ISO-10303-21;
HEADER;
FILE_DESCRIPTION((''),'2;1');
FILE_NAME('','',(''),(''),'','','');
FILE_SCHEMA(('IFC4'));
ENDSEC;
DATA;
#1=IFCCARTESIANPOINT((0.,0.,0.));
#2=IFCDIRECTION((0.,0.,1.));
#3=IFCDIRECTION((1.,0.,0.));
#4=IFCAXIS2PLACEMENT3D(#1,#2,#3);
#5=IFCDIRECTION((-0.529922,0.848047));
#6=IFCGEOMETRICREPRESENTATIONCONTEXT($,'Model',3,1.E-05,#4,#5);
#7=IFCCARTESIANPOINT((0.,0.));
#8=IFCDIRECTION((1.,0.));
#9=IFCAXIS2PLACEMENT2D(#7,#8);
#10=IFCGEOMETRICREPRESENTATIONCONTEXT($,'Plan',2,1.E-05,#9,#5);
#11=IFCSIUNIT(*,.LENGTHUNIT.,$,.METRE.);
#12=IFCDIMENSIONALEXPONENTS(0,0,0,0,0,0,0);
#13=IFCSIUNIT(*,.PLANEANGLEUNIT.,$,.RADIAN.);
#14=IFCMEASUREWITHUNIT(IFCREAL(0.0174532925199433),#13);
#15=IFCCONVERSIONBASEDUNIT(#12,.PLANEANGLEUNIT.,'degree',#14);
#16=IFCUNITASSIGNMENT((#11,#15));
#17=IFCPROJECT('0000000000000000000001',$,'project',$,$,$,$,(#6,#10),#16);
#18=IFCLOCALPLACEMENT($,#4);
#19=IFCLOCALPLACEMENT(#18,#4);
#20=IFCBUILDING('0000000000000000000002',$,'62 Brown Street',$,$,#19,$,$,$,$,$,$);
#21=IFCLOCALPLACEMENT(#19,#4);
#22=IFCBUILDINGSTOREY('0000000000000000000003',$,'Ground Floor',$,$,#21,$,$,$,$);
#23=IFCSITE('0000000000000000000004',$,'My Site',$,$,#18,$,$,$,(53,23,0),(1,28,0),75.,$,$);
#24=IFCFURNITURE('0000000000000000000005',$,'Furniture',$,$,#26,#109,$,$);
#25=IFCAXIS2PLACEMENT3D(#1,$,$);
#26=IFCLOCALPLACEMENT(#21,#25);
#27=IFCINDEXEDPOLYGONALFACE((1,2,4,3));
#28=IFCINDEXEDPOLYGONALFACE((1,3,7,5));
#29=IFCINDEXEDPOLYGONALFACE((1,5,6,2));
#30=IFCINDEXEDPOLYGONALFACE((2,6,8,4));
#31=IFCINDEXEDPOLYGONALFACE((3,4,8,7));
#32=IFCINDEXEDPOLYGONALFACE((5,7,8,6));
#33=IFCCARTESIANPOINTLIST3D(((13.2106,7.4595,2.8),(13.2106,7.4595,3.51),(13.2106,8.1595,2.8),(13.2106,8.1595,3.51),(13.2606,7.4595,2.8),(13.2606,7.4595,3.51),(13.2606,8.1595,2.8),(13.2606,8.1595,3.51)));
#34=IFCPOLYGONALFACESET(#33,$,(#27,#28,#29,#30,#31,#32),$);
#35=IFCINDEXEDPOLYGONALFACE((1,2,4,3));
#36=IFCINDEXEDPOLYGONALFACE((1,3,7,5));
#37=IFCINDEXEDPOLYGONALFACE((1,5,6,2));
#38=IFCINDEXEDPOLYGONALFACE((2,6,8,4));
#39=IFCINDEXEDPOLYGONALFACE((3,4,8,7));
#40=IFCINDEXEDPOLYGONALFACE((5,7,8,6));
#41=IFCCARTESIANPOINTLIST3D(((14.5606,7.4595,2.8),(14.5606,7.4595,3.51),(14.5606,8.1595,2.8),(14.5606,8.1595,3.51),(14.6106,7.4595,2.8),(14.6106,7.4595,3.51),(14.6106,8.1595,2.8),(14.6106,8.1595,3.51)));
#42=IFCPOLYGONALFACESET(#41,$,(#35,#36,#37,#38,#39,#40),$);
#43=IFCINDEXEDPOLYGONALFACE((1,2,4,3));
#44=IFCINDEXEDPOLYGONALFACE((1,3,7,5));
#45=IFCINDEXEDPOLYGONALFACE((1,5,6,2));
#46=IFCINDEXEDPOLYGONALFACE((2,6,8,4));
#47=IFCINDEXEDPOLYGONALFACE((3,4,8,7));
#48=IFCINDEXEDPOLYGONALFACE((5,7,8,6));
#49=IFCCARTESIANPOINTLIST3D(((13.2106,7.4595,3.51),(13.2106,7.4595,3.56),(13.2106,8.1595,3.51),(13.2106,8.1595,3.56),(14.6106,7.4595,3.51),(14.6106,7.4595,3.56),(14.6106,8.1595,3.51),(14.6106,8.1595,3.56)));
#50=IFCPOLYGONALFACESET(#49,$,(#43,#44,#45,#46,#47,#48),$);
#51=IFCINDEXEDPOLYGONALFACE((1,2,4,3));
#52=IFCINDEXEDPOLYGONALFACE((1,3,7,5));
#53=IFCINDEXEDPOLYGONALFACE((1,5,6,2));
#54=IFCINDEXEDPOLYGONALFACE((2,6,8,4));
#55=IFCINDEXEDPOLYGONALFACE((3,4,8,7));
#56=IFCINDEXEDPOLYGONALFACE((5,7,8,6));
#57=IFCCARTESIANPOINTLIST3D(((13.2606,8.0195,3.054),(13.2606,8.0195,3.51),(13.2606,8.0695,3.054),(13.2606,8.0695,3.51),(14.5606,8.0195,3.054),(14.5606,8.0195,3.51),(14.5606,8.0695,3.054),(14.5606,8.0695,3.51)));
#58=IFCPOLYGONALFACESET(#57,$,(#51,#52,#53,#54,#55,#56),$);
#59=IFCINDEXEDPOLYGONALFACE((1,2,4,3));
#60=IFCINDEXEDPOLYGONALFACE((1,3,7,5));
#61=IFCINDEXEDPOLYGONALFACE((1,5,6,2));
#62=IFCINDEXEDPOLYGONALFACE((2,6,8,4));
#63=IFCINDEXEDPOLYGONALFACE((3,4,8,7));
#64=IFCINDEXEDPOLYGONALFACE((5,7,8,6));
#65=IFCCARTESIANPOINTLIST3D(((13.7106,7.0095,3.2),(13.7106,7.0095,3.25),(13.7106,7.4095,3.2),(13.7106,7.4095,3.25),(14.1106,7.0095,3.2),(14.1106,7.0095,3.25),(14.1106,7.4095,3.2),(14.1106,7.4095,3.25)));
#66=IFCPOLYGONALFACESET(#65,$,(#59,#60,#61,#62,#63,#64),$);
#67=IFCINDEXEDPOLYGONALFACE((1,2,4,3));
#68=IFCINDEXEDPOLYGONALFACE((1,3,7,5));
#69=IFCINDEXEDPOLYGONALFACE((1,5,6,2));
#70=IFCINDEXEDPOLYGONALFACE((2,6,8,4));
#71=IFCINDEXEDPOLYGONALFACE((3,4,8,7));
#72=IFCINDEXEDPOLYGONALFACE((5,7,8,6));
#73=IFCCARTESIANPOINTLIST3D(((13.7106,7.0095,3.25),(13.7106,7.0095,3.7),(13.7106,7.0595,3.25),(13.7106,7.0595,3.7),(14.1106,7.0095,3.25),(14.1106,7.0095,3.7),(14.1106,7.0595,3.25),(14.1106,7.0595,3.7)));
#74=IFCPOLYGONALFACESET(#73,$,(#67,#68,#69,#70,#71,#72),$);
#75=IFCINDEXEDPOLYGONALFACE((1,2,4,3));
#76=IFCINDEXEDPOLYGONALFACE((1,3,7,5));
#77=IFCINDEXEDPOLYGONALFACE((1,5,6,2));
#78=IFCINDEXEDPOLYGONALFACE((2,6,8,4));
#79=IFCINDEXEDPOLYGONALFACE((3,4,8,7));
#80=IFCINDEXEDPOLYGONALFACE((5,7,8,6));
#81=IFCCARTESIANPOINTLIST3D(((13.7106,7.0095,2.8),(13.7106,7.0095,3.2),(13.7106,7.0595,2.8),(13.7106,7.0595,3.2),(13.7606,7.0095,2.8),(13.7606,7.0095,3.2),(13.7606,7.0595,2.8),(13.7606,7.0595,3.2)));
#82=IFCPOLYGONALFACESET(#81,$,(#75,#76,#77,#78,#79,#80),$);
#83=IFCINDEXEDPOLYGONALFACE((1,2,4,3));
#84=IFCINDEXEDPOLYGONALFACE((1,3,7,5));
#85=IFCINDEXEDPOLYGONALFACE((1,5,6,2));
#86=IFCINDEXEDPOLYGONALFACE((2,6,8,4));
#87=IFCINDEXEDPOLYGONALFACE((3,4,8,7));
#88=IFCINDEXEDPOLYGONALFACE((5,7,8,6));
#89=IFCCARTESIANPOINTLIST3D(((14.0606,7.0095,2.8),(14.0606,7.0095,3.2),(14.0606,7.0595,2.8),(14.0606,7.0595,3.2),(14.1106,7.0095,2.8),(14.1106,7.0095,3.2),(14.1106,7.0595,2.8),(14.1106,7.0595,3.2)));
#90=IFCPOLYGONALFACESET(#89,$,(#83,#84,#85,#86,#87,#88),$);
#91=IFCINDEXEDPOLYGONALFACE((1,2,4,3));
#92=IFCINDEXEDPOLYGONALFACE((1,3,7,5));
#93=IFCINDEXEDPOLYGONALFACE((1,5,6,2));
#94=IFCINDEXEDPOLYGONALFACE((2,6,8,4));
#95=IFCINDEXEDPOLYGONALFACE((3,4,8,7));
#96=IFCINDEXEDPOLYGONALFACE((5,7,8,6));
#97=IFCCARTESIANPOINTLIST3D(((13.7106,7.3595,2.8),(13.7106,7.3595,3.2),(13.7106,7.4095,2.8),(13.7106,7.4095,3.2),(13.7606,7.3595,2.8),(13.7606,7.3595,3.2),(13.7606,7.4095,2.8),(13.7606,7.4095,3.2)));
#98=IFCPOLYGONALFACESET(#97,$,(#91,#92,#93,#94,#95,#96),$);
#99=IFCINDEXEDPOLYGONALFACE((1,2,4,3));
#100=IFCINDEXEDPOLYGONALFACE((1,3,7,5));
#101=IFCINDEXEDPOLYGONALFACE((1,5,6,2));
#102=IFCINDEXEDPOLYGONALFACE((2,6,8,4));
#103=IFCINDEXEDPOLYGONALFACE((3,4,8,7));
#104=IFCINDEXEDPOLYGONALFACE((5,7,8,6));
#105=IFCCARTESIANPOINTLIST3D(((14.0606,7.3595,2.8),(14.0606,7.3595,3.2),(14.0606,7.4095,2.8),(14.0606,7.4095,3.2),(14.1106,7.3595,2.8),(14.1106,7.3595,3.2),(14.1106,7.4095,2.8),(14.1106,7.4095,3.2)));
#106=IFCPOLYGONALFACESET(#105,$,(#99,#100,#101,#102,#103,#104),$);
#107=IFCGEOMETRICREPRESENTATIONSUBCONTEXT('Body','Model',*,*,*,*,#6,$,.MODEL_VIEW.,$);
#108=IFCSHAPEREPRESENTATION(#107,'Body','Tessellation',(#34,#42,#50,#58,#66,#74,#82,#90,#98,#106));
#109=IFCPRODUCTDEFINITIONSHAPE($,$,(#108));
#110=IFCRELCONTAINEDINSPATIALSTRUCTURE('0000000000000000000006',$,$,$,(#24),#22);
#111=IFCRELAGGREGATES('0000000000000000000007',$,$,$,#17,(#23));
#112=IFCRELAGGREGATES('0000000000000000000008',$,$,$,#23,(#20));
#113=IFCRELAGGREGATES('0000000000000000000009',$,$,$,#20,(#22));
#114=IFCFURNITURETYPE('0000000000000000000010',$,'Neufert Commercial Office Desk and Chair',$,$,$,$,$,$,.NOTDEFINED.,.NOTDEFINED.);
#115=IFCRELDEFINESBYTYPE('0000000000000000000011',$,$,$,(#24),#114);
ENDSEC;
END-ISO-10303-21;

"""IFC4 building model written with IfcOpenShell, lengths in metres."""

from ifc_helpers import new_model, entity, si_unit, converted_unit, direction, frame, origin_with_axes, origin_2d_with_axis, place, context, subcontext, project, spatial, line, indexed_curve, outline, extrude, shape, source, transform, mapped, type_object, type_shapes, element, save


model = new_model("IFC4")

# Units and contexts
model_context = context("Model", 3, precision=1e-05, world=origin_with_axes(), true_north=direction((-0.529922, 0.848047)))
plan_context = context("Plan", 2, precision=1e-05, world=origin_2d_with_axis(), true_north=direction((-0.529922, 0.848047)))
body_context_1 = subcontext(model_context, "Body", "Model", "MODEL_VIEW")
body_context_2 = subcontext(plan_context, "Body", "Plan", "PLAN_VIEW")
ifc_project = project(units=[si_unit("LENGTHUNIT", "METRE"), converted_unit("PLANEANGLEUNIT", "degree", entity("IfcReal", 0.0174532925199433), si_unit("PLANEANGLEUNIT", "RADIAN"), dimensions=[0, 0, 0, 0, 0, 0, 0])], contexts=[model_context, plan_context])

# Site, building, storey
site_placement = place(None, origin_with_axes())
site = spatial("IfcSite", under=ifc_project, at=site_placement, Name="My Site", RefLatitude=(53, 23, 0), RefLongitude=(1, 28, 0), RefElevation=75.0)
building_placement = place(site_placement, origin_with_axes())
building = spatial("IfcBuilding", under=site, at=building_placement, Name="62 Brown Street")
storey_placement = place(building_placement, origin_with_axes())
storey = spatial("IfcBuildingStorey", under=building, at=storey_placement, Name="Ground Floor")

# Furniture
furniture_type_1 = type_object("IfcFurnitureType", Name="Neufert Commercial Office Desk and Chair", AssemblyPlace="NOTDEFINED", PredefinedType="NOTDEFINED")
shared_shape_1 = source(origin_with_axes(), body_context_1, "Body", "SweptSolid", [
    extrude(outline(indexed_curve([(0.0, 0.0), (0.05, 0.0), (0.05, 0.7), (0.0, 0.7)], segments=[line(1, 2, 3, 4, 1)])), frame((0.0, 0.45, 0.0), z_axis=(0.0, 0.0, 1.0), x_axis=(1.0, 0.0, 0.0)), (0.0, 0.0, 1.0), 0.71),
    extrude(outline(indexed_curve([(0.0, 0.0), (0.05, 0.0), (0.05, 0.7), (0.0, 0.7)], segments=[line(1, 2, 3, 4, 1)])), frame((1.35, 0.45, 0.0), z_axis=(0.0, 0.0, 1.0), x_axis=(1.0, 0.0, 0.0)), (0.0, 0.0, 1.0), 0.71),
    extrude(outline(indexed_curve([(0.0, 0.0), (1.4, 0.0), (1.4, 0.7), (0.0, 0.7)], segments=[line(1, 2, 3, 4, 1)])), frame((0.0, 0.45, 0.71), z_axis=(0.0, 0.0, 1.0), x_axis=(1.0, 0.0, 0.0)), (0.0, 0.0, 1.0), 0.05),
    extrude(outline(indexed_curve([(0.05, 0.56), (1.35, 0.56), (1.35, 0.61), (0.05, 0.61)], segments=[line(1, 2, 3, 4, 1)])), frame((0.0, 0.45, 0.254), z_axis=(0.0, 0.0, 1.0), x_axis=(1.0, 0.0, 0.0)), (0.0, 0.0, 1.0), 0.456),
    extrude(outline(indexed_curve([(-0.2, 0.0), (0.2, 0.0), (0.2, 0.4), (-0.2, 0.4)], segments=[line(1, 2, 3, 4, 1)])), frame((0.7, 0.0, 0.45), z_axis=(0.0, 0.0, 1.0), x_axis=(1.0, 0.0, 0.0)), (0.0, 0.0, -1.0), 0.05),
    extrude(outline(indexed_curve([(-0.2, 0.0), (0.2, 0.0), (0.2, 0.05), (-0.2, 0.05)], segments=[line(1, 2, 3, 4, 1)])), frame((0.7, 0.0, 0.9), z_axis=(0.0, 0.0, 1.0), x_axis=(1.0, 0.0, 0.0)), (0.0, 0.0, -1.0), 0.45),
    extrude(outline(indexed_curve([(-0.2, 0.0), (-0.15, 0.0), (-0.15, 0.05), (-0.2, 0.05)], segments=[line(1, 2, 3, 4, 1)])), frame((0.7, 0.0, 0.0), z_axis=(0.0, 0.0, 1.0), x_axis=(1.0, 0.0, 0.0)), (0.0, 0.0, 1.0), 0.4),
    extrude(outline(indexed_curve([(0.2, 0.0), (0.15, 0.0), (0.15, 0.05), (0.2, 0.05)], segments=[line(1, 2, 3, 4, 1)])), frame((0.7, 0.0, 0.0), z_axis=(0.0, 0.0, 1.0), x_axis=(1.0, 0.0, 0.0)), (0.0, 0.0, 1.0), 0.4),
    extrude(outline(indexed_curve([(-0.2, 0.4), (-0.15, 0.4), (-0.15, 0.35), (-0.2, 0.35)], segments=[line(1, 2, 3, 4, 1)])), frame((0.7, 0.0, 0.0), z_axis=(0.0, 0.0, 1.0), x_axis=(1.0, 0.0, 0.0)), (0.0, 0.0, 1.0), 0.4),
    extrude(outline(indexed_curve([(0.2, 0.4), (0.15, 0.4), (0.15, 0.35), (0.2, 0.35)], segments=[line(1, 2, 3, 4, 1)])), frame((0.7, 0.0, 0.0), z_axis=(0.0, 0.0, 1.0), x_axis=(1.0, 0.0, 0.0)), (0.0, 0.0, 1.0), 0.4),
])
shared_shape_2 = source(origin_with_axes(), body_context_2, "Body", "Curve2D", [
    entity("IfcIndexedPolyCurve", entity("IfcCartesianPointList2D", [[0.0, 0.45], [1.4, 0.45], [1.4, 1.15], [0.0, 1.15]]), [entity("IfcLineIndex", [1, 2, 3, 4, 1])]),
    entity("IfcIndexedPolyCurve", entity("IfcCartesianPointList2D", [[0.5, 0.4], [0.9, 0.4]])),
    entity("IfcIndexedPolyCurve", entity("IfcCartesianPointList2D", [[0.5, 0.4], [0.5, 0.2], [0.5586, 0.0586], [0.7, 0.0], [0.8414, 0.0586], [0.9, 0.2], [0.9, 0.4]]), [entity("IfcLineIndex", [1, 2]), entity("IfcArcIndex", [2, 3, 4]), entity("IfcArcIndex", [4, 5, 6]), entity("IfcLineIndex", [6, 7])]),
    entity("IfcIndexedPolyCurve", entity("IfcCartesianPointList2D", [[0.54, 0.4], [0.54, 0.2], [0.5869, 0.0869], [0.7, 0.04], [0.8131, 0.0869], [0.86, 0.2], [0.86, 0.4]]), [entity("IfcLineIndex", [1, 2]), entity("IfcArcIndex", [2, 3, 4]), entity("IfcArcIndex", [4, 5, 6]), entity("IfcLineIndex", [6, 7])]),
])
type_shapes(furniture_type_1, [shared_shape_1, shared_shape_2])
furniture_1_placement = place(storey_placement, frame((13.2106, 7.0095, 2.8), z_axis=(0.0, 0.0, 1.0), x_axis=(1.0, 0.0, 0.0)))
element("IfcFurniture", 1, at=furniture_1_placement, inside=storey, type_object=furniture_type_1, Name="Furniture", shapes=[
    shape(body_context_1, "Body", "MappedRepresentation", [mapped(shared_shape_1, transform((0.0, 0.0, 0.0), x_axis=(1.0, 0.0, 0.0), y_axis=(0.0, 1.0, 0.0), z_axis=(0.0, 0.0, 1.0), scale=1.0))]),
    shape(body_context_2, "Body", "MappedRepresentation", [mapped(shared_shape_2, transform((0.0, 0.0, 0.0), x_axis=(1.0, 0.0, 0.0), y_axis=(0.0, 1.0, 0.0), z_axis=(0.0, 0.0, 1.0), scale=1.0))]),
])

save(model, "model.ifc")
